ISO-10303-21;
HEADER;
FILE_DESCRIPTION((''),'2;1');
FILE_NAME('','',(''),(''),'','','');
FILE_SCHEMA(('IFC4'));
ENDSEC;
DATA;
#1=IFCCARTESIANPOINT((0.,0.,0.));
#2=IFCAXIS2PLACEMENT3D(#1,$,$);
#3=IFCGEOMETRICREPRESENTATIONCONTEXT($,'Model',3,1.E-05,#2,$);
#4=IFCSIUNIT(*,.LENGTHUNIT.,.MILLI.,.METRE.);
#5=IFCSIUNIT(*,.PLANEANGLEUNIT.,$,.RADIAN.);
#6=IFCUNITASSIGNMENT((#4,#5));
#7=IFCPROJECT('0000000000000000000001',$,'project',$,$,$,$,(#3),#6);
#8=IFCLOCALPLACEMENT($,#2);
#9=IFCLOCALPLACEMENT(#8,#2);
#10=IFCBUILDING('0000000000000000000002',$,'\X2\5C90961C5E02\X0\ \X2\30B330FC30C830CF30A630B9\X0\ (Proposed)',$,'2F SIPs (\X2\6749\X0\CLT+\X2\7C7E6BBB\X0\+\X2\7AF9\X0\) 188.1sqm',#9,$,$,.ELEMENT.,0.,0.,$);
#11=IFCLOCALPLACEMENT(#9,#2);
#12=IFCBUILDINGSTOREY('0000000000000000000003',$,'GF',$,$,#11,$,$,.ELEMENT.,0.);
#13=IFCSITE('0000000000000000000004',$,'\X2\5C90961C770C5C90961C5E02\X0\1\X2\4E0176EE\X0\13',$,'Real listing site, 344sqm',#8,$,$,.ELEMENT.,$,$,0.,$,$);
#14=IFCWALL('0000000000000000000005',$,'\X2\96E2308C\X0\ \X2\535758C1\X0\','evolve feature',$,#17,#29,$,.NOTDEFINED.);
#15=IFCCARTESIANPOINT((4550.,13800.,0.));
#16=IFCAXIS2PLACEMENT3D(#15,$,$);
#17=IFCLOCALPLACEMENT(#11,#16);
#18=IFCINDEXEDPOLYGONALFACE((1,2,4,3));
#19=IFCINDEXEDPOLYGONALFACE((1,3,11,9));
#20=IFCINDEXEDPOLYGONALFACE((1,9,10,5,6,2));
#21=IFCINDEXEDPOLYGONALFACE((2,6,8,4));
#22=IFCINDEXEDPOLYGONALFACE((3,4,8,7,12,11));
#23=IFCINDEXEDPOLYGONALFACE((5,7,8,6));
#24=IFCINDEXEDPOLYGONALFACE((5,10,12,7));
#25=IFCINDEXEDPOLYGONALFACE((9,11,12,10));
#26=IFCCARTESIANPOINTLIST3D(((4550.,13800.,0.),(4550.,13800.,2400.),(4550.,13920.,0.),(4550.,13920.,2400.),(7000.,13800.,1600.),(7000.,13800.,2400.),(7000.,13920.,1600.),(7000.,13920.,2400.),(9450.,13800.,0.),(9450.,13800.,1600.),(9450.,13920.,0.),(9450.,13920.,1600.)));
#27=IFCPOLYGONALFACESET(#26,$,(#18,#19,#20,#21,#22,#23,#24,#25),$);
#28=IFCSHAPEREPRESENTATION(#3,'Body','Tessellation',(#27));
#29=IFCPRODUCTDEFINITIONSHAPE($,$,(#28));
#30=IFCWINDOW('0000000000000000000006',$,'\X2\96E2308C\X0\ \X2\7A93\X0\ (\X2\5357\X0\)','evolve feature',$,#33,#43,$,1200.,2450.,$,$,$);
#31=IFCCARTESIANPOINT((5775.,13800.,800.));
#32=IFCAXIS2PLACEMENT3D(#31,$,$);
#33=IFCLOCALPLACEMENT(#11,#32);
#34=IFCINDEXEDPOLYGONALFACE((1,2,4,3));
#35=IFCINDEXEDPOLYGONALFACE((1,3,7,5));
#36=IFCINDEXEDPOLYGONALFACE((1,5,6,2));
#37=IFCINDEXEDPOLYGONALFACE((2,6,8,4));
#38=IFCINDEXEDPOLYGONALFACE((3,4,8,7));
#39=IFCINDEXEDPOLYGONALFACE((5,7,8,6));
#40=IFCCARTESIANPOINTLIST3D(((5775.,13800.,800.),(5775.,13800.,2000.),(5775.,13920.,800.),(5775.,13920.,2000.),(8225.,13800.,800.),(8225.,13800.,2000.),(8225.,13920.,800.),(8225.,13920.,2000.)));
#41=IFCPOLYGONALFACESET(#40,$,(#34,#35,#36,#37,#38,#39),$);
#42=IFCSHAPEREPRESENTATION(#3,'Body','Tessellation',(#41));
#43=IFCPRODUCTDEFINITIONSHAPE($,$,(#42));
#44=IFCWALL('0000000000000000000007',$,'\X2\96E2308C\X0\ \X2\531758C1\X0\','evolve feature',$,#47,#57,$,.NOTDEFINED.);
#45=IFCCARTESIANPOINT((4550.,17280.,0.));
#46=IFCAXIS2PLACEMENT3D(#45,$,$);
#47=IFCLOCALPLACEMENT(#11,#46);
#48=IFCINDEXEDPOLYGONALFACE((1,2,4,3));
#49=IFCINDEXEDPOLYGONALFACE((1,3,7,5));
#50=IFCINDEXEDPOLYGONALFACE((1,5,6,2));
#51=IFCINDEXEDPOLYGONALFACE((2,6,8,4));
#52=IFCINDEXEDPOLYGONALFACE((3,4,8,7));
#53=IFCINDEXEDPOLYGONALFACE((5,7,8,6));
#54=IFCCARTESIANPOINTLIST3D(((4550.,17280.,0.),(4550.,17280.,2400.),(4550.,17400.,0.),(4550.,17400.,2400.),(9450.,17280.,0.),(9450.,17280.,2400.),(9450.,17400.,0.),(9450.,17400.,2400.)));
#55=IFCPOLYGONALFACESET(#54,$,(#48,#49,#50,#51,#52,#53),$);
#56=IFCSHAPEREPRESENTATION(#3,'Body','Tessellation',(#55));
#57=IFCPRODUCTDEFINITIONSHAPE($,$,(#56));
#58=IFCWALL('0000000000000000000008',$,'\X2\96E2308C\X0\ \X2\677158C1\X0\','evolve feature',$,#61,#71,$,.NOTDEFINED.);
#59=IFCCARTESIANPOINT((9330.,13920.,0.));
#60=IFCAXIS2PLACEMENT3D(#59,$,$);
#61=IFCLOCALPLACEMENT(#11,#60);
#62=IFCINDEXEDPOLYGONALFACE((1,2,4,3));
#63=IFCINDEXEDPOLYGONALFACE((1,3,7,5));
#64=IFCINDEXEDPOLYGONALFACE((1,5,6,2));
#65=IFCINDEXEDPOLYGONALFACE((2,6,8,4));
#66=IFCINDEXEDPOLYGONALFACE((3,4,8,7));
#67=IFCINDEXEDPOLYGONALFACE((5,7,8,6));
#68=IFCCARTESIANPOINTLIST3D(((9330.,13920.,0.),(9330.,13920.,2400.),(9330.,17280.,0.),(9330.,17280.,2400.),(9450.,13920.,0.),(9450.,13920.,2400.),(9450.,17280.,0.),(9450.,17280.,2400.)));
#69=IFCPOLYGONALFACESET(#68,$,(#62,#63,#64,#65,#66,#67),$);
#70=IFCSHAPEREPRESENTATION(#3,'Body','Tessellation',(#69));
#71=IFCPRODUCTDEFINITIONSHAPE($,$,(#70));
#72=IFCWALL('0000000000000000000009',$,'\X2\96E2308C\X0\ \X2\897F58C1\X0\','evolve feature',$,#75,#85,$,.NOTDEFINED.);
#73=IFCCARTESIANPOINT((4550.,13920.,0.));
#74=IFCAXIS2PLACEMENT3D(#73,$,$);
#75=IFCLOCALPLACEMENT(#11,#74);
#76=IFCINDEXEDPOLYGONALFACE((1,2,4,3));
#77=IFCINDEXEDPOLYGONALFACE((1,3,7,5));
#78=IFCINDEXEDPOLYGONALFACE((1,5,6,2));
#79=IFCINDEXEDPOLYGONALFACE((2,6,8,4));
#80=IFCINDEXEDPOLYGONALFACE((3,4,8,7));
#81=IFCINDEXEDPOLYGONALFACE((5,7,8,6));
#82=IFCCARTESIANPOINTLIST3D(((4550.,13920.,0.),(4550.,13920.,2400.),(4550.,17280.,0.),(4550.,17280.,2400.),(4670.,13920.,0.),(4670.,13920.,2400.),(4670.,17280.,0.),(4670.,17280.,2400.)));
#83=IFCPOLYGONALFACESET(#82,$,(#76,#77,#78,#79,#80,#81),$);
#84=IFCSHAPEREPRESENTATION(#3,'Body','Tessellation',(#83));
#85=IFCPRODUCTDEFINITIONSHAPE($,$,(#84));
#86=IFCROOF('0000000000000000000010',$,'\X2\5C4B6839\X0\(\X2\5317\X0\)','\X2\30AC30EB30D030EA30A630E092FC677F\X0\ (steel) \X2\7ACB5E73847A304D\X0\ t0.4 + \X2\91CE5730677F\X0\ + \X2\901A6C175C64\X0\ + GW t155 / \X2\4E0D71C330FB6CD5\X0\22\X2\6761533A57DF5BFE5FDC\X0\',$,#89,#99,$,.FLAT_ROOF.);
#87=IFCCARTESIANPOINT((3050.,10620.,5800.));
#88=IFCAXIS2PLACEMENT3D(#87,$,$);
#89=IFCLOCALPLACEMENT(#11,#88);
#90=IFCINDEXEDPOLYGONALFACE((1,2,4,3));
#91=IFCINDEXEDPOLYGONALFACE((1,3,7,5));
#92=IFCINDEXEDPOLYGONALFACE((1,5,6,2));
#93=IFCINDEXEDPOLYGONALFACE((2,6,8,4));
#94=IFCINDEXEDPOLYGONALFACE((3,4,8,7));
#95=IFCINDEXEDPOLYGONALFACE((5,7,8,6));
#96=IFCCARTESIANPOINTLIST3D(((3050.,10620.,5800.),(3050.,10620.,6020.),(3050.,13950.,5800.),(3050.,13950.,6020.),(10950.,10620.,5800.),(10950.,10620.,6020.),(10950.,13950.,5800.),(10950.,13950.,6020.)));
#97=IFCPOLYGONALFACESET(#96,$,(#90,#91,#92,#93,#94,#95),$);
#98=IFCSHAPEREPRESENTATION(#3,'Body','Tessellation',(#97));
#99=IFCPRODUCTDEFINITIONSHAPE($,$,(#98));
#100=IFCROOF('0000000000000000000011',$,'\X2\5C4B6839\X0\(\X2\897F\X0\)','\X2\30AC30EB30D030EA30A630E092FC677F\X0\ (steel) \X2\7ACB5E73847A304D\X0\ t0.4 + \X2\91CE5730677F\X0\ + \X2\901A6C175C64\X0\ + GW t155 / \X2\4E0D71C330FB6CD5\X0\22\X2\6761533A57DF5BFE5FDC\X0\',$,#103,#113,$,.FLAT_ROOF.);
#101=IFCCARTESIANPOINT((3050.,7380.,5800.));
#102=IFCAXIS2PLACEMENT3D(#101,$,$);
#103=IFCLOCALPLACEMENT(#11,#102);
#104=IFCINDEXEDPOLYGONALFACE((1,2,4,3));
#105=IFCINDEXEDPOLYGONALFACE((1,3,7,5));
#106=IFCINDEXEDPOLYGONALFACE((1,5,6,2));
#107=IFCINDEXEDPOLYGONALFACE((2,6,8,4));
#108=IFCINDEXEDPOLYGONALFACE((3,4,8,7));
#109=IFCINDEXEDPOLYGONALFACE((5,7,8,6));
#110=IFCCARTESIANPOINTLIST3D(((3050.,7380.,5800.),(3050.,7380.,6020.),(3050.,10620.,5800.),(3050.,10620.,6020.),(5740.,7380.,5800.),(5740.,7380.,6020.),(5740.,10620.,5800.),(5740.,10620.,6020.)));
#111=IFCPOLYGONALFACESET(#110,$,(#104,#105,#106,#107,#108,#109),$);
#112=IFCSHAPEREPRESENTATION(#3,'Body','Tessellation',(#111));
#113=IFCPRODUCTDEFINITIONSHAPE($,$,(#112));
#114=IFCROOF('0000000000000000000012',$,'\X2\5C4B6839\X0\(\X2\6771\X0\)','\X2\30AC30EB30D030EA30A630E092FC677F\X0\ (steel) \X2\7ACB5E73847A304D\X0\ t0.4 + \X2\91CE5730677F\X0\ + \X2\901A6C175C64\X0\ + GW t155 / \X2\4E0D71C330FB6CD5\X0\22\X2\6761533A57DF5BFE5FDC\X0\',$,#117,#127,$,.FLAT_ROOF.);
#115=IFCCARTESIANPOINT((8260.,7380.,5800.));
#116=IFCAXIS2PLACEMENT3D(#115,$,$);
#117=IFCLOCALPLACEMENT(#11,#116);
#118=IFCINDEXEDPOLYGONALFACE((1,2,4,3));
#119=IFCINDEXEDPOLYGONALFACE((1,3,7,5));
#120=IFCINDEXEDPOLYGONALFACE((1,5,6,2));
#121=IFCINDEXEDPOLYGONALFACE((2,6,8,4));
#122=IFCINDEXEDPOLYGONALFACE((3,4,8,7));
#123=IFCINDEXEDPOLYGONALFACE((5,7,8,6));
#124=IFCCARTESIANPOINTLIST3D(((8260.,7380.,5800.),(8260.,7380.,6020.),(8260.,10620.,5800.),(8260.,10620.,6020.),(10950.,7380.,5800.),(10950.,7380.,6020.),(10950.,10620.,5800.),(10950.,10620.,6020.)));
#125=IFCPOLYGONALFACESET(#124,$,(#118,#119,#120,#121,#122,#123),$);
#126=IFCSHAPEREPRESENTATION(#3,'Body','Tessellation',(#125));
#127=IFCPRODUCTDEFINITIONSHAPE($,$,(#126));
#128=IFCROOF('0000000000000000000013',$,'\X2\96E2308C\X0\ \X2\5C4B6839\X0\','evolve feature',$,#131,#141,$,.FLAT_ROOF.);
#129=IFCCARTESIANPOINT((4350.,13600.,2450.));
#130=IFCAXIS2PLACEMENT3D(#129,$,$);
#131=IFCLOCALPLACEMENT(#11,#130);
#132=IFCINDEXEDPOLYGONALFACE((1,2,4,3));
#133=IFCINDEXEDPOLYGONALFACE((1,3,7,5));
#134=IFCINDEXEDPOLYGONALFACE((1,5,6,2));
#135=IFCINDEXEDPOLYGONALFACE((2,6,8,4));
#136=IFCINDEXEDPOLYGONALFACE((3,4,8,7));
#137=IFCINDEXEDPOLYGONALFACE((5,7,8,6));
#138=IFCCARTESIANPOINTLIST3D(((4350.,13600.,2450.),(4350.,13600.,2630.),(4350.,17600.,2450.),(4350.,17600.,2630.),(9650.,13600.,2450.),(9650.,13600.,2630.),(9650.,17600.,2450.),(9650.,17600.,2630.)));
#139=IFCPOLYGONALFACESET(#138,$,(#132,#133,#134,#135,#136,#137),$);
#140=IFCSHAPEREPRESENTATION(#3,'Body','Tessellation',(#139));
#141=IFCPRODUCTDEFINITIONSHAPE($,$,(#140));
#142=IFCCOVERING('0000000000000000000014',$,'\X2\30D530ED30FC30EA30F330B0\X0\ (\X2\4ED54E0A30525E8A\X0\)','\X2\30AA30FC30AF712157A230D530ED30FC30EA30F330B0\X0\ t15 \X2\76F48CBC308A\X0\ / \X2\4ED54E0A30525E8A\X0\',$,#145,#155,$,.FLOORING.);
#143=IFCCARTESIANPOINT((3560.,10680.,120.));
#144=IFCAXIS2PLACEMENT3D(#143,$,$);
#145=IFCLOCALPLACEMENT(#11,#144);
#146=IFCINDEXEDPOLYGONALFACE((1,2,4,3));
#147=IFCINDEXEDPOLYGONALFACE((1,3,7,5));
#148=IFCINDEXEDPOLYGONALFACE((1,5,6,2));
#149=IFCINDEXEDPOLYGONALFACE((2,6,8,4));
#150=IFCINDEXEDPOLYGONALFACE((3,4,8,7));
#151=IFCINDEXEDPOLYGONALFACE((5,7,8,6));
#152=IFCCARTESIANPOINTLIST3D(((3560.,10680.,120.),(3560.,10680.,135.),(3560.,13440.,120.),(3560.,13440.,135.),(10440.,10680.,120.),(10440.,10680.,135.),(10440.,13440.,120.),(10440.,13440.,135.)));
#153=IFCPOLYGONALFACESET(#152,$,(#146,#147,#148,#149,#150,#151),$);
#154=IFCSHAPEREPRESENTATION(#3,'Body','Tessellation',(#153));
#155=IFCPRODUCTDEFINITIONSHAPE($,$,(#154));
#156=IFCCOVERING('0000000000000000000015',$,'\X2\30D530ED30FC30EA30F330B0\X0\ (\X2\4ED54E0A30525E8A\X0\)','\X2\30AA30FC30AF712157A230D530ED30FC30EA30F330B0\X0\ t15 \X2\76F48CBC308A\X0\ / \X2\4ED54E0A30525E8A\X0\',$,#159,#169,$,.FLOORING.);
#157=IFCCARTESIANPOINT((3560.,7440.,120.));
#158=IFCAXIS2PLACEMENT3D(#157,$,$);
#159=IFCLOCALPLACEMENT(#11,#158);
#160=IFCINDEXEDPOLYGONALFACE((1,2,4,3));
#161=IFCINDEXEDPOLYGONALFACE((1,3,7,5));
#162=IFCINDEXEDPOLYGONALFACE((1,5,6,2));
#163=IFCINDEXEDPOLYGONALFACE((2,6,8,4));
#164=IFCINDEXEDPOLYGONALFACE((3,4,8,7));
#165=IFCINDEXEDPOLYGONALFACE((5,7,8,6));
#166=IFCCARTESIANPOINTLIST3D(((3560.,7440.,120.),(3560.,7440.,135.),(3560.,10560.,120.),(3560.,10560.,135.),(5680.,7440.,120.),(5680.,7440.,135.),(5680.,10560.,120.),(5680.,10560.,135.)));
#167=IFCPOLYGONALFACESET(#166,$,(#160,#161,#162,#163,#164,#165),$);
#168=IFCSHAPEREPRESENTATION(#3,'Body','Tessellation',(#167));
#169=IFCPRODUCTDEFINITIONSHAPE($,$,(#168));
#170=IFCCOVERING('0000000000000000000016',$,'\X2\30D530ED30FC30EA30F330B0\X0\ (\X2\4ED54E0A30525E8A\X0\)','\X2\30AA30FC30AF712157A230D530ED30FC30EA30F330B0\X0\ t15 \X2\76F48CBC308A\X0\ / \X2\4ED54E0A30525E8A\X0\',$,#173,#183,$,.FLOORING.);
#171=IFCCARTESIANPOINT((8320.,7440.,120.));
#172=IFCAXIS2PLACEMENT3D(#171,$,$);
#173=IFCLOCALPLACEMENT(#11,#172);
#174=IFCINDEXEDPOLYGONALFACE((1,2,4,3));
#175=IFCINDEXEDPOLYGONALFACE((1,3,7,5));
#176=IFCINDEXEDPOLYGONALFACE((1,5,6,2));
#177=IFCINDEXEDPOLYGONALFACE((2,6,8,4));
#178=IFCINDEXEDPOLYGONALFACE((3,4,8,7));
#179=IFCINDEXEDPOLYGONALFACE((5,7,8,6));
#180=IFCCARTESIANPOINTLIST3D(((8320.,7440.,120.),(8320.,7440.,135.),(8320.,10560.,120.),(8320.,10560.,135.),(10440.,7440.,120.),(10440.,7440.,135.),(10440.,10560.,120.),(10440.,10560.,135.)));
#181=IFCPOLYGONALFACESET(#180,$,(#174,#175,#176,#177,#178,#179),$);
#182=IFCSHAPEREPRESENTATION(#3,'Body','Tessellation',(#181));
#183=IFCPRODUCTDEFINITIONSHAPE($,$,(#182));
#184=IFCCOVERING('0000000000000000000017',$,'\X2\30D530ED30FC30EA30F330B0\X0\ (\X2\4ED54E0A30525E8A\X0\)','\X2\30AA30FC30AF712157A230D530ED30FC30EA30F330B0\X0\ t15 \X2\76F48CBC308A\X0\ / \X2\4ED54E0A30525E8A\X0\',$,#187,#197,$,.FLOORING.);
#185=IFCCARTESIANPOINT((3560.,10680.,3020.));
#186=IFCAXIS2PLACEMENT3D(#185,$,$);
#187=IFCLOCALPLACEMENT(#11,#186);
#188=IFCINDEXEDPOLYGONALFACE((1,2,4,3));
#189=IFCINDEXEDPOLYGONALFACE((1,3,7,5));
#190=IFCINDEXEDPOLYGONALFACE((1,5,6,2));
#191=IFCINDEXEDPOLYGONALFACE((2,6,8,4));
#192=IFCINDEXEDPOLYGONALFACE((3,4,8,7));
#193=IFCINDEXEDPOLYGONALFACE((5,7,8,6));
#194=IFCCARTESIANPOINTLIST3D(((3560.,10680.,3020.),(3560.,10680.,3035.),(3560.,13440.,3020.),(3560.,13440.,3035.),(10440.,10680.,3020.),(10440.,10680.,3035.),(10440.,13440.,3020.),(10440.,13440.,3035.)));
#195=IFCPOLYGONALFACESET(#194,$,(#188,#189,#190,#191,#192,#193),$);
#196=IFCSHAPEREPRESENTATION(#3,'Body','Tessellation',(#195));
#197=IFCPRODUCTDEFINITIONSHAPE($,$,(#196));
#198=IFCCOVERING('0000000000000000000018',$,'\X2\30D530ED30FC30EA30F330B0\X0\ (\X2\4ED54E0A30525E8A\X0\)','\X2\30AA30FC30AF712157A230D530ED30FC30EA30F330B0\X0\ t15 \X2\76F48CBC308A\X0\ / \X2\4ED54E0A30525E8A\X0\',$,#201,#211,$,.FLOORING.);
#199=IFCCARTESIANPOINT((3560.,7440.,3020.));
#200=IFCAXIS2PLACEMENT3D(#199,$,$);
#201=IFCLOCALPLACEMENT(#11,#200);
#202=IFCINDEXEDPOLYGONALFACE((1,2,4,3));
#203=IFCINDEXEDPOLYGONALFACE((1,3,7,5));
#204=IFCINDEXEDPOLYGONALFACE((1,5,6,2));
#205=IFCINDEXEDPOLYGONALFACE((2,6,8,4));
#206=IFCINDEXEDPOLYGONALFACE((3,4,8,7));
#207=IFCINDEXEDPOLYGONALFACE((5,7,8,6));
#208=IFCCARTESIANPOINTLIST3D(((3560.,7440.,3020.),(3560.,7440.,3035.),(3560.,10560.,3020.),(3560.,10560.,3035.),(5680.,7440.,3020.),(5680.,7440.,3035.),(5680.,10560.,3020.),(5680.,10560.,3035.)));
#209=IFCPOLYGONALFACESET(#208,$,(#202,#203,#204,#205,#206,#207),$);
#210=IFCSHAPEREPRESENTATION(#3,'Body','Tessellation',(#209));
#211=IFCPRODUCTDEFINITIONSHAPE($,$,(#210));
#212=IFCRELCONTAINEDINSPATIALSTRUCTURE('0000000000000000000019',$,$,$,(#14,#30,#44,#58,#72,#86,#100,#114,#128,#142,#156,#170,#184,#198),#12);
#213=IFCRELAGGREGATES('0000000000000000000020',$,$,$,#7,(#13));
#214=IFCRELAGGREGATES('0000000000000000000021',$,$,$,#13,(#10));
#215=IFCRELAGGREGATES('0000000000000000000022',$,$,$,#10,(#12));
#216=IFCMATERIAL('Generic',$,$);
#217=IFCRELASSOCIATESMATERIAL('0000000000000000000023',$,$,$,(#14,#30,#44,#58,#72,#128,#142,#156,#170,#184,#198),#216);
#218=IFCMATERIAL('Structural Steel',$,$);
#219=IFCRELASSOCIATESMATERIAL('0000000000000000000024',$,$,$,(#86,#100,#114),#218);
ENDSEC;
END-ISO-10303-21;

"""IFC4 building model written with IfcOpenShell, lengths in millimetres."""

from ifc_helpers import new_model, si_unit, frame, frame_2d, origin, place, context, project, spatial, rectangle, extrude, material, element, fill, save


model = new_model("IFC4")

# Units and contexts
model_context = context("Model", 3, precision=1e-05, world=origin())
ifc_project = project(units=[si_unit("LENGTHUNIT", "METRE", prefix="MILLI"), si_unit("PLANEANGLEUNIT", "RADIAN")], contexts=[model_context])

# Site, building, storey
site_placement = place(None, origin())
site = spatial("IfcSite", under=ifc_project, at=site_placement, Name="岐阜県岐阜市1丁目13", ObjectType="Real listing site, 344sqm", CompositionType="ELEMENT", RefElevation=0.0)
building_placement = place(site_placement, origin())
building = spatial("IfcBuilding", under=site, at=building_placement, Name="岐阜市 コートハウス (Proposed)", ObjectType="2F SIPs (杉CLT+籾殻+竹) 188.1sqm", CompositionType="ELEMENT", ElevationOfRefHeight=0.0, ElevationOfTerrain=0.0)
storey_placement = place(building_placement, origin())
storey = spatial("IfcBuildingStorey", under=building, at=storey_placement, Name="GF", CompositionType="ELEMENT", Elevation=0.0)

# Shared definitions
ifc_material_1 = material(Name="Generic")

# Wall, opening, window
wall_1_placement = place(storey_placement, frame((4550.0, 13800.0, 0.0)))
wall_1 = element("IfcWall", 1, at=wall_1_placement, inside=storey, material=ifc_material_1, Name="離れ 南壁", Description="evolve feature", PredefinedType="NOTDEFINED", context=model_context, shape_type="SweptSolid", body=[
    extrude(rectangle(XDim=4900.0, YDim=120.0, at=frame_2d((2450.0, 60.0))), frame((4550.0, 13800.0, 0.0)), (0.0, 0.0, 1.0), 2400.0),
])
opening_1_placement = place(storey_placement, frame((5775.0, 13800.0, 800.0)))
opening_1 = element("IfcOpeningElement", 2, at=opening_1_placement, cuts=wall_1, PredefinedType="NOTDEFINED", context=model_context, shape_type="SweptSolid", body=[
    extrude(rectangle(XDim=2450.0, YDim=120.0, at=frame_2d((1225.0, 60.0))), frame((5775.0, 13800.0, 800.0)), (0.0, 0.0, 1.0), 1200.0),
])
window_1_placement = place(storey_placement, frame((5775.0, 13800.0, 800.0)))
window_1 = element("IfcWindow", 3, at=window_1_placement, inside=storey, material=ifc_material_1, Name="離れ 窓 (南)", Description="evolve feature", OverallHeight=1200.0, OverallWidth=2450.0, context=model_context, shape_type="SweptSolid", body=[
    extrude(rectangle(XDim=2450.0, YDim=120.0, at=frame_2d((1225.0, 60.0))), frame((5775.0, 13800.0, 800.0)), (0.0, 0.0, 1.0), 1200.0),
])
fill(opening_1, window_1)

# Walls
wall_2_placement = place(storey_placement, frame((4550.0, 17280.0, 0.0)))
element("IfcWall", 4, at=wall_2_placement, inside=storey, material=ifc_material_1, Name="離れ 北壁", Description="evolve feature", PredefinedType="NOTDEFINED", context=model_context, shape_type="SweptSolid", body=[
    extrude(rectangle(XDim=4900.0, YDim=120.0, at=frame_2d((2450.0, 60.0))), frame((4550.0, 17280.0, 0.0)), (0.0, 0.0, 1.0), 2400.0),
])
wall_3_placement = place(storey_placement, frame((9330.0, 13920.0, 0.0)))
element("IfcWall", 5, at=wall_3_placement, inside=storey, material=ifc_material_1, Name="離れ 東壁", Description="evolve feature", PredefinedType="NOTDEFINED", context=model_context, shape_type="SweptSolid", body=[
    extrude(rectangle(XDim=120.0, YDim=3360.0, at=frame_2d((60.0, 1680.0))), frame((9330.0, 13920.0, 0.0)), (0.0, 0.0, 1.0), 2400.0),
])
wall_4_placement = place(storey_placement, frame((4550.0, 13920.0, 0.0)))
element("IfcWall", 6, at=wall_4_placement, inside=storey, material=ifc_material_1, Name="離れ 西壁", Description="evolve feature", PredefinedType="NOTDEFINED", context=model_context, shape_type="SweptSolid", body=[
    extrude(rectangle(XDim=120.0, YDim=3360.0, at=frame_2d((60.0, 1680.0))), frame((4550.0, 13920.0, 0.0)), (0.0, 0.0, 1.0), 2400.0),
])

# Roofs
ifc_material_2 = material(Name="Structural Steel")
for number, where, name in (
    (7, (3050.0, 10620.0, 5800.0), "屋根(北)"),
):
    element("IfcRoof", number, at=place(storey_placement, frame(where)), inside=storey, material=ifc_material_2, Name=name, Description="ガルバリウム鋼板 (steel) 立平葺き t0.4 + 野地板 + 通気層 + GW t155 / 不燃・法22条区域対応", PredefinedType="FLAT_ROOF", context=model_context, shape_type="SweptSolid", body=[
        extrude(rectangle(XDim=7900.0, YDim=3330.0, at=frame_2d((3950.0, 1665.0))), frame((3050.0, 10620.0, 5800.0)), (0.0, 0.0, 1.0), 220.0),
    ])
roof_1_placement = place(storey_placement, frame((3050.0, 7380.0, 5800.0)))
element("IfcRoof", 8, at=roof_1_placement, inside=storey, material=ifc_material_2, Name="屋根(西)", Description="ガルバリウム鋼板 (steel) 立平葺き t0.4 + 野地板 + 通気層 + GW t155 / 不燃・法22条区域対応", PredefinedType="FLAT_ROOF", context=model_context, shape_type="SweptSolid", body=[
    extrude(rectangle(XDim=2690.0, YDim=3240.0, at=frame_2d((1345.0, 1620.0))), frame((3050.0, 7380.0, 5800.0)), (0.0, 0.0, 1.0), 220.0),
])
roof_2_placement = place(storey_placement, frame((8260.0, 7380.0, 5800.0)))
element("IfcRoof", 9, at=roof_2_placement, inside=storey, material=ifc_material_2, Name="屋根(東)", Description="ガルバリウム鋼板 (steel) 立平葺き t0.4 + 野地板 + 通気層 + GW t155 / 不燃・法22条区域対応", PredefinedType="FLAT_ROOF", context=model_context, shape_type="SweptSolid", body=[
    extrude(rectangle(XDim=2690.0, YDim=3240.0, at=frame_2d((1345.0, 1620.0))), frame((8260.0, 7380.0, 5800.0)), (0.0, 0.0, 1.0), 220.0),
])
roof_3_placement = place(storey_placement, frame((4350.0, 13600.0, 2450.0)))
element("IfcRoof", 10, at=roof_3_placement, inside=storey, material=ifc_material_1, Name="離れ 屋根", Description="evolve feature", PredefinedType="FLAT_ROOF", context=model_context, shape_type="SweptSolid", body=[
    extrude(rectangle(XDim=5300.0, YDim=4000.0, at=frame_2d((2650.0, 2000.0))), frame((4350.0, 13600.0, 2450.0)), (0.0, 0.0, 1.0), 180.0),
])

# Coverings
covering_1_placement = place(storey_placement, frame((3560.0, 10680.0, 120.0)))
element("IfcCovering", 11, at=covering_1_placement, inside=storey, material=ifc_material_1, Name="フローリング (仕上げ床)", Description="オーク無垢フローリング t15 直貼り / 仕上げ床", PredefinedType="FLOORING", context=model_context, shape_type="SweptSolid", body=[
    extrude(rectangle(XDim=6880.0, YDim=2760.0, at=frame_2d((3440.0, 1380.0))), frame((3560.0, 10680.0, 120.0)), (0.0, 0.0, 1.0), 15.0),
])
covering_2_placement = place(storey_placement, frame((3560.0, 7440.0, 120.0)))
element("IfcCovering", 12, at=covering_2_placement, inside=storey, material=ifc_material_1, Name="フローリング (仕上げ床)", Description="オーク無垢フローリング t15 直貼り / 仕上げ床", PredefinedType="FLOORING", context=model_context, shape_type="SweptSolid", body=[
    extrude(rectangle(XDim=2120.0, YDim=3120.0, at=frame_2d((1060.0, 1560.0))), frame((3560.0, 7440.0, 120.0)), (0.0, 0.0, 1.0), 15.0),
])
covering_3_placement = place(storey_placement, frame((8320.0, 7440.0, 120.0)))
element("IfcCovering", 13, at=covering_3_placement, inside=storey, material=ifc_material_1, Name="フローリング (仕上げ床)", Description="オーク無垢フローリング t15 直貼り / 仕上げ床", PredefinedType="FLOORING", context=model_context, shape_type="SweptSolid", body=[
    extrude(rectangle(XDim=2120.0, YDim=3120.0, at=frame_2d((1060.0, 1560.0))), frame((8320.0, 7440.0, 120.0)), (0.0, 0.0, 1.0), 15.0),
])
covering_4_placement = place(storey_placement, frame((3560.0, 10680.0, 3020.0)))
element("IfcCovering", 14, at=covering_4_placement, inside=storey, material=ifc_material_1, Name="フローリング (仕上げ床)", Description="オーク無垢フローリング t15 直貼り / 仕上げ床", PredefinedType="FLOORING", context=model_context, shape_type="SweptSolid", body=[
    extrude(rectangle(XDim=6880.0, YDim=2760.0, at=frame_2d((3440.0, 1380.0))), frame((3560.0, 10680.0, 3020.0)), (0.0, 0.0, 1.0), 15.0),
])
covering_5_placement = place(storey_placement, frame((3560.0, 7440.0, 3020.0)))
element("IfcCovering", 15, at=covering_5_placement, inside=storey, material=ifc_material_1, Name="フローリング (仕上げ床)", Description="オーク無垢フローリング t15 直貼り / 仕上げ床", PredefinedType="FLOORING", context=model_context, shape_type="SweptSolid", body=[
    extrude(rectangle(XDim=2120.0, YDim=3120.0, at=frame_2d((1060.0, 1560.0))), frame((3560.0, 7440.0, 3020.0)), (0.0, 0.0, 1.0), 15.0),
])

save(model, "model.ifc")
